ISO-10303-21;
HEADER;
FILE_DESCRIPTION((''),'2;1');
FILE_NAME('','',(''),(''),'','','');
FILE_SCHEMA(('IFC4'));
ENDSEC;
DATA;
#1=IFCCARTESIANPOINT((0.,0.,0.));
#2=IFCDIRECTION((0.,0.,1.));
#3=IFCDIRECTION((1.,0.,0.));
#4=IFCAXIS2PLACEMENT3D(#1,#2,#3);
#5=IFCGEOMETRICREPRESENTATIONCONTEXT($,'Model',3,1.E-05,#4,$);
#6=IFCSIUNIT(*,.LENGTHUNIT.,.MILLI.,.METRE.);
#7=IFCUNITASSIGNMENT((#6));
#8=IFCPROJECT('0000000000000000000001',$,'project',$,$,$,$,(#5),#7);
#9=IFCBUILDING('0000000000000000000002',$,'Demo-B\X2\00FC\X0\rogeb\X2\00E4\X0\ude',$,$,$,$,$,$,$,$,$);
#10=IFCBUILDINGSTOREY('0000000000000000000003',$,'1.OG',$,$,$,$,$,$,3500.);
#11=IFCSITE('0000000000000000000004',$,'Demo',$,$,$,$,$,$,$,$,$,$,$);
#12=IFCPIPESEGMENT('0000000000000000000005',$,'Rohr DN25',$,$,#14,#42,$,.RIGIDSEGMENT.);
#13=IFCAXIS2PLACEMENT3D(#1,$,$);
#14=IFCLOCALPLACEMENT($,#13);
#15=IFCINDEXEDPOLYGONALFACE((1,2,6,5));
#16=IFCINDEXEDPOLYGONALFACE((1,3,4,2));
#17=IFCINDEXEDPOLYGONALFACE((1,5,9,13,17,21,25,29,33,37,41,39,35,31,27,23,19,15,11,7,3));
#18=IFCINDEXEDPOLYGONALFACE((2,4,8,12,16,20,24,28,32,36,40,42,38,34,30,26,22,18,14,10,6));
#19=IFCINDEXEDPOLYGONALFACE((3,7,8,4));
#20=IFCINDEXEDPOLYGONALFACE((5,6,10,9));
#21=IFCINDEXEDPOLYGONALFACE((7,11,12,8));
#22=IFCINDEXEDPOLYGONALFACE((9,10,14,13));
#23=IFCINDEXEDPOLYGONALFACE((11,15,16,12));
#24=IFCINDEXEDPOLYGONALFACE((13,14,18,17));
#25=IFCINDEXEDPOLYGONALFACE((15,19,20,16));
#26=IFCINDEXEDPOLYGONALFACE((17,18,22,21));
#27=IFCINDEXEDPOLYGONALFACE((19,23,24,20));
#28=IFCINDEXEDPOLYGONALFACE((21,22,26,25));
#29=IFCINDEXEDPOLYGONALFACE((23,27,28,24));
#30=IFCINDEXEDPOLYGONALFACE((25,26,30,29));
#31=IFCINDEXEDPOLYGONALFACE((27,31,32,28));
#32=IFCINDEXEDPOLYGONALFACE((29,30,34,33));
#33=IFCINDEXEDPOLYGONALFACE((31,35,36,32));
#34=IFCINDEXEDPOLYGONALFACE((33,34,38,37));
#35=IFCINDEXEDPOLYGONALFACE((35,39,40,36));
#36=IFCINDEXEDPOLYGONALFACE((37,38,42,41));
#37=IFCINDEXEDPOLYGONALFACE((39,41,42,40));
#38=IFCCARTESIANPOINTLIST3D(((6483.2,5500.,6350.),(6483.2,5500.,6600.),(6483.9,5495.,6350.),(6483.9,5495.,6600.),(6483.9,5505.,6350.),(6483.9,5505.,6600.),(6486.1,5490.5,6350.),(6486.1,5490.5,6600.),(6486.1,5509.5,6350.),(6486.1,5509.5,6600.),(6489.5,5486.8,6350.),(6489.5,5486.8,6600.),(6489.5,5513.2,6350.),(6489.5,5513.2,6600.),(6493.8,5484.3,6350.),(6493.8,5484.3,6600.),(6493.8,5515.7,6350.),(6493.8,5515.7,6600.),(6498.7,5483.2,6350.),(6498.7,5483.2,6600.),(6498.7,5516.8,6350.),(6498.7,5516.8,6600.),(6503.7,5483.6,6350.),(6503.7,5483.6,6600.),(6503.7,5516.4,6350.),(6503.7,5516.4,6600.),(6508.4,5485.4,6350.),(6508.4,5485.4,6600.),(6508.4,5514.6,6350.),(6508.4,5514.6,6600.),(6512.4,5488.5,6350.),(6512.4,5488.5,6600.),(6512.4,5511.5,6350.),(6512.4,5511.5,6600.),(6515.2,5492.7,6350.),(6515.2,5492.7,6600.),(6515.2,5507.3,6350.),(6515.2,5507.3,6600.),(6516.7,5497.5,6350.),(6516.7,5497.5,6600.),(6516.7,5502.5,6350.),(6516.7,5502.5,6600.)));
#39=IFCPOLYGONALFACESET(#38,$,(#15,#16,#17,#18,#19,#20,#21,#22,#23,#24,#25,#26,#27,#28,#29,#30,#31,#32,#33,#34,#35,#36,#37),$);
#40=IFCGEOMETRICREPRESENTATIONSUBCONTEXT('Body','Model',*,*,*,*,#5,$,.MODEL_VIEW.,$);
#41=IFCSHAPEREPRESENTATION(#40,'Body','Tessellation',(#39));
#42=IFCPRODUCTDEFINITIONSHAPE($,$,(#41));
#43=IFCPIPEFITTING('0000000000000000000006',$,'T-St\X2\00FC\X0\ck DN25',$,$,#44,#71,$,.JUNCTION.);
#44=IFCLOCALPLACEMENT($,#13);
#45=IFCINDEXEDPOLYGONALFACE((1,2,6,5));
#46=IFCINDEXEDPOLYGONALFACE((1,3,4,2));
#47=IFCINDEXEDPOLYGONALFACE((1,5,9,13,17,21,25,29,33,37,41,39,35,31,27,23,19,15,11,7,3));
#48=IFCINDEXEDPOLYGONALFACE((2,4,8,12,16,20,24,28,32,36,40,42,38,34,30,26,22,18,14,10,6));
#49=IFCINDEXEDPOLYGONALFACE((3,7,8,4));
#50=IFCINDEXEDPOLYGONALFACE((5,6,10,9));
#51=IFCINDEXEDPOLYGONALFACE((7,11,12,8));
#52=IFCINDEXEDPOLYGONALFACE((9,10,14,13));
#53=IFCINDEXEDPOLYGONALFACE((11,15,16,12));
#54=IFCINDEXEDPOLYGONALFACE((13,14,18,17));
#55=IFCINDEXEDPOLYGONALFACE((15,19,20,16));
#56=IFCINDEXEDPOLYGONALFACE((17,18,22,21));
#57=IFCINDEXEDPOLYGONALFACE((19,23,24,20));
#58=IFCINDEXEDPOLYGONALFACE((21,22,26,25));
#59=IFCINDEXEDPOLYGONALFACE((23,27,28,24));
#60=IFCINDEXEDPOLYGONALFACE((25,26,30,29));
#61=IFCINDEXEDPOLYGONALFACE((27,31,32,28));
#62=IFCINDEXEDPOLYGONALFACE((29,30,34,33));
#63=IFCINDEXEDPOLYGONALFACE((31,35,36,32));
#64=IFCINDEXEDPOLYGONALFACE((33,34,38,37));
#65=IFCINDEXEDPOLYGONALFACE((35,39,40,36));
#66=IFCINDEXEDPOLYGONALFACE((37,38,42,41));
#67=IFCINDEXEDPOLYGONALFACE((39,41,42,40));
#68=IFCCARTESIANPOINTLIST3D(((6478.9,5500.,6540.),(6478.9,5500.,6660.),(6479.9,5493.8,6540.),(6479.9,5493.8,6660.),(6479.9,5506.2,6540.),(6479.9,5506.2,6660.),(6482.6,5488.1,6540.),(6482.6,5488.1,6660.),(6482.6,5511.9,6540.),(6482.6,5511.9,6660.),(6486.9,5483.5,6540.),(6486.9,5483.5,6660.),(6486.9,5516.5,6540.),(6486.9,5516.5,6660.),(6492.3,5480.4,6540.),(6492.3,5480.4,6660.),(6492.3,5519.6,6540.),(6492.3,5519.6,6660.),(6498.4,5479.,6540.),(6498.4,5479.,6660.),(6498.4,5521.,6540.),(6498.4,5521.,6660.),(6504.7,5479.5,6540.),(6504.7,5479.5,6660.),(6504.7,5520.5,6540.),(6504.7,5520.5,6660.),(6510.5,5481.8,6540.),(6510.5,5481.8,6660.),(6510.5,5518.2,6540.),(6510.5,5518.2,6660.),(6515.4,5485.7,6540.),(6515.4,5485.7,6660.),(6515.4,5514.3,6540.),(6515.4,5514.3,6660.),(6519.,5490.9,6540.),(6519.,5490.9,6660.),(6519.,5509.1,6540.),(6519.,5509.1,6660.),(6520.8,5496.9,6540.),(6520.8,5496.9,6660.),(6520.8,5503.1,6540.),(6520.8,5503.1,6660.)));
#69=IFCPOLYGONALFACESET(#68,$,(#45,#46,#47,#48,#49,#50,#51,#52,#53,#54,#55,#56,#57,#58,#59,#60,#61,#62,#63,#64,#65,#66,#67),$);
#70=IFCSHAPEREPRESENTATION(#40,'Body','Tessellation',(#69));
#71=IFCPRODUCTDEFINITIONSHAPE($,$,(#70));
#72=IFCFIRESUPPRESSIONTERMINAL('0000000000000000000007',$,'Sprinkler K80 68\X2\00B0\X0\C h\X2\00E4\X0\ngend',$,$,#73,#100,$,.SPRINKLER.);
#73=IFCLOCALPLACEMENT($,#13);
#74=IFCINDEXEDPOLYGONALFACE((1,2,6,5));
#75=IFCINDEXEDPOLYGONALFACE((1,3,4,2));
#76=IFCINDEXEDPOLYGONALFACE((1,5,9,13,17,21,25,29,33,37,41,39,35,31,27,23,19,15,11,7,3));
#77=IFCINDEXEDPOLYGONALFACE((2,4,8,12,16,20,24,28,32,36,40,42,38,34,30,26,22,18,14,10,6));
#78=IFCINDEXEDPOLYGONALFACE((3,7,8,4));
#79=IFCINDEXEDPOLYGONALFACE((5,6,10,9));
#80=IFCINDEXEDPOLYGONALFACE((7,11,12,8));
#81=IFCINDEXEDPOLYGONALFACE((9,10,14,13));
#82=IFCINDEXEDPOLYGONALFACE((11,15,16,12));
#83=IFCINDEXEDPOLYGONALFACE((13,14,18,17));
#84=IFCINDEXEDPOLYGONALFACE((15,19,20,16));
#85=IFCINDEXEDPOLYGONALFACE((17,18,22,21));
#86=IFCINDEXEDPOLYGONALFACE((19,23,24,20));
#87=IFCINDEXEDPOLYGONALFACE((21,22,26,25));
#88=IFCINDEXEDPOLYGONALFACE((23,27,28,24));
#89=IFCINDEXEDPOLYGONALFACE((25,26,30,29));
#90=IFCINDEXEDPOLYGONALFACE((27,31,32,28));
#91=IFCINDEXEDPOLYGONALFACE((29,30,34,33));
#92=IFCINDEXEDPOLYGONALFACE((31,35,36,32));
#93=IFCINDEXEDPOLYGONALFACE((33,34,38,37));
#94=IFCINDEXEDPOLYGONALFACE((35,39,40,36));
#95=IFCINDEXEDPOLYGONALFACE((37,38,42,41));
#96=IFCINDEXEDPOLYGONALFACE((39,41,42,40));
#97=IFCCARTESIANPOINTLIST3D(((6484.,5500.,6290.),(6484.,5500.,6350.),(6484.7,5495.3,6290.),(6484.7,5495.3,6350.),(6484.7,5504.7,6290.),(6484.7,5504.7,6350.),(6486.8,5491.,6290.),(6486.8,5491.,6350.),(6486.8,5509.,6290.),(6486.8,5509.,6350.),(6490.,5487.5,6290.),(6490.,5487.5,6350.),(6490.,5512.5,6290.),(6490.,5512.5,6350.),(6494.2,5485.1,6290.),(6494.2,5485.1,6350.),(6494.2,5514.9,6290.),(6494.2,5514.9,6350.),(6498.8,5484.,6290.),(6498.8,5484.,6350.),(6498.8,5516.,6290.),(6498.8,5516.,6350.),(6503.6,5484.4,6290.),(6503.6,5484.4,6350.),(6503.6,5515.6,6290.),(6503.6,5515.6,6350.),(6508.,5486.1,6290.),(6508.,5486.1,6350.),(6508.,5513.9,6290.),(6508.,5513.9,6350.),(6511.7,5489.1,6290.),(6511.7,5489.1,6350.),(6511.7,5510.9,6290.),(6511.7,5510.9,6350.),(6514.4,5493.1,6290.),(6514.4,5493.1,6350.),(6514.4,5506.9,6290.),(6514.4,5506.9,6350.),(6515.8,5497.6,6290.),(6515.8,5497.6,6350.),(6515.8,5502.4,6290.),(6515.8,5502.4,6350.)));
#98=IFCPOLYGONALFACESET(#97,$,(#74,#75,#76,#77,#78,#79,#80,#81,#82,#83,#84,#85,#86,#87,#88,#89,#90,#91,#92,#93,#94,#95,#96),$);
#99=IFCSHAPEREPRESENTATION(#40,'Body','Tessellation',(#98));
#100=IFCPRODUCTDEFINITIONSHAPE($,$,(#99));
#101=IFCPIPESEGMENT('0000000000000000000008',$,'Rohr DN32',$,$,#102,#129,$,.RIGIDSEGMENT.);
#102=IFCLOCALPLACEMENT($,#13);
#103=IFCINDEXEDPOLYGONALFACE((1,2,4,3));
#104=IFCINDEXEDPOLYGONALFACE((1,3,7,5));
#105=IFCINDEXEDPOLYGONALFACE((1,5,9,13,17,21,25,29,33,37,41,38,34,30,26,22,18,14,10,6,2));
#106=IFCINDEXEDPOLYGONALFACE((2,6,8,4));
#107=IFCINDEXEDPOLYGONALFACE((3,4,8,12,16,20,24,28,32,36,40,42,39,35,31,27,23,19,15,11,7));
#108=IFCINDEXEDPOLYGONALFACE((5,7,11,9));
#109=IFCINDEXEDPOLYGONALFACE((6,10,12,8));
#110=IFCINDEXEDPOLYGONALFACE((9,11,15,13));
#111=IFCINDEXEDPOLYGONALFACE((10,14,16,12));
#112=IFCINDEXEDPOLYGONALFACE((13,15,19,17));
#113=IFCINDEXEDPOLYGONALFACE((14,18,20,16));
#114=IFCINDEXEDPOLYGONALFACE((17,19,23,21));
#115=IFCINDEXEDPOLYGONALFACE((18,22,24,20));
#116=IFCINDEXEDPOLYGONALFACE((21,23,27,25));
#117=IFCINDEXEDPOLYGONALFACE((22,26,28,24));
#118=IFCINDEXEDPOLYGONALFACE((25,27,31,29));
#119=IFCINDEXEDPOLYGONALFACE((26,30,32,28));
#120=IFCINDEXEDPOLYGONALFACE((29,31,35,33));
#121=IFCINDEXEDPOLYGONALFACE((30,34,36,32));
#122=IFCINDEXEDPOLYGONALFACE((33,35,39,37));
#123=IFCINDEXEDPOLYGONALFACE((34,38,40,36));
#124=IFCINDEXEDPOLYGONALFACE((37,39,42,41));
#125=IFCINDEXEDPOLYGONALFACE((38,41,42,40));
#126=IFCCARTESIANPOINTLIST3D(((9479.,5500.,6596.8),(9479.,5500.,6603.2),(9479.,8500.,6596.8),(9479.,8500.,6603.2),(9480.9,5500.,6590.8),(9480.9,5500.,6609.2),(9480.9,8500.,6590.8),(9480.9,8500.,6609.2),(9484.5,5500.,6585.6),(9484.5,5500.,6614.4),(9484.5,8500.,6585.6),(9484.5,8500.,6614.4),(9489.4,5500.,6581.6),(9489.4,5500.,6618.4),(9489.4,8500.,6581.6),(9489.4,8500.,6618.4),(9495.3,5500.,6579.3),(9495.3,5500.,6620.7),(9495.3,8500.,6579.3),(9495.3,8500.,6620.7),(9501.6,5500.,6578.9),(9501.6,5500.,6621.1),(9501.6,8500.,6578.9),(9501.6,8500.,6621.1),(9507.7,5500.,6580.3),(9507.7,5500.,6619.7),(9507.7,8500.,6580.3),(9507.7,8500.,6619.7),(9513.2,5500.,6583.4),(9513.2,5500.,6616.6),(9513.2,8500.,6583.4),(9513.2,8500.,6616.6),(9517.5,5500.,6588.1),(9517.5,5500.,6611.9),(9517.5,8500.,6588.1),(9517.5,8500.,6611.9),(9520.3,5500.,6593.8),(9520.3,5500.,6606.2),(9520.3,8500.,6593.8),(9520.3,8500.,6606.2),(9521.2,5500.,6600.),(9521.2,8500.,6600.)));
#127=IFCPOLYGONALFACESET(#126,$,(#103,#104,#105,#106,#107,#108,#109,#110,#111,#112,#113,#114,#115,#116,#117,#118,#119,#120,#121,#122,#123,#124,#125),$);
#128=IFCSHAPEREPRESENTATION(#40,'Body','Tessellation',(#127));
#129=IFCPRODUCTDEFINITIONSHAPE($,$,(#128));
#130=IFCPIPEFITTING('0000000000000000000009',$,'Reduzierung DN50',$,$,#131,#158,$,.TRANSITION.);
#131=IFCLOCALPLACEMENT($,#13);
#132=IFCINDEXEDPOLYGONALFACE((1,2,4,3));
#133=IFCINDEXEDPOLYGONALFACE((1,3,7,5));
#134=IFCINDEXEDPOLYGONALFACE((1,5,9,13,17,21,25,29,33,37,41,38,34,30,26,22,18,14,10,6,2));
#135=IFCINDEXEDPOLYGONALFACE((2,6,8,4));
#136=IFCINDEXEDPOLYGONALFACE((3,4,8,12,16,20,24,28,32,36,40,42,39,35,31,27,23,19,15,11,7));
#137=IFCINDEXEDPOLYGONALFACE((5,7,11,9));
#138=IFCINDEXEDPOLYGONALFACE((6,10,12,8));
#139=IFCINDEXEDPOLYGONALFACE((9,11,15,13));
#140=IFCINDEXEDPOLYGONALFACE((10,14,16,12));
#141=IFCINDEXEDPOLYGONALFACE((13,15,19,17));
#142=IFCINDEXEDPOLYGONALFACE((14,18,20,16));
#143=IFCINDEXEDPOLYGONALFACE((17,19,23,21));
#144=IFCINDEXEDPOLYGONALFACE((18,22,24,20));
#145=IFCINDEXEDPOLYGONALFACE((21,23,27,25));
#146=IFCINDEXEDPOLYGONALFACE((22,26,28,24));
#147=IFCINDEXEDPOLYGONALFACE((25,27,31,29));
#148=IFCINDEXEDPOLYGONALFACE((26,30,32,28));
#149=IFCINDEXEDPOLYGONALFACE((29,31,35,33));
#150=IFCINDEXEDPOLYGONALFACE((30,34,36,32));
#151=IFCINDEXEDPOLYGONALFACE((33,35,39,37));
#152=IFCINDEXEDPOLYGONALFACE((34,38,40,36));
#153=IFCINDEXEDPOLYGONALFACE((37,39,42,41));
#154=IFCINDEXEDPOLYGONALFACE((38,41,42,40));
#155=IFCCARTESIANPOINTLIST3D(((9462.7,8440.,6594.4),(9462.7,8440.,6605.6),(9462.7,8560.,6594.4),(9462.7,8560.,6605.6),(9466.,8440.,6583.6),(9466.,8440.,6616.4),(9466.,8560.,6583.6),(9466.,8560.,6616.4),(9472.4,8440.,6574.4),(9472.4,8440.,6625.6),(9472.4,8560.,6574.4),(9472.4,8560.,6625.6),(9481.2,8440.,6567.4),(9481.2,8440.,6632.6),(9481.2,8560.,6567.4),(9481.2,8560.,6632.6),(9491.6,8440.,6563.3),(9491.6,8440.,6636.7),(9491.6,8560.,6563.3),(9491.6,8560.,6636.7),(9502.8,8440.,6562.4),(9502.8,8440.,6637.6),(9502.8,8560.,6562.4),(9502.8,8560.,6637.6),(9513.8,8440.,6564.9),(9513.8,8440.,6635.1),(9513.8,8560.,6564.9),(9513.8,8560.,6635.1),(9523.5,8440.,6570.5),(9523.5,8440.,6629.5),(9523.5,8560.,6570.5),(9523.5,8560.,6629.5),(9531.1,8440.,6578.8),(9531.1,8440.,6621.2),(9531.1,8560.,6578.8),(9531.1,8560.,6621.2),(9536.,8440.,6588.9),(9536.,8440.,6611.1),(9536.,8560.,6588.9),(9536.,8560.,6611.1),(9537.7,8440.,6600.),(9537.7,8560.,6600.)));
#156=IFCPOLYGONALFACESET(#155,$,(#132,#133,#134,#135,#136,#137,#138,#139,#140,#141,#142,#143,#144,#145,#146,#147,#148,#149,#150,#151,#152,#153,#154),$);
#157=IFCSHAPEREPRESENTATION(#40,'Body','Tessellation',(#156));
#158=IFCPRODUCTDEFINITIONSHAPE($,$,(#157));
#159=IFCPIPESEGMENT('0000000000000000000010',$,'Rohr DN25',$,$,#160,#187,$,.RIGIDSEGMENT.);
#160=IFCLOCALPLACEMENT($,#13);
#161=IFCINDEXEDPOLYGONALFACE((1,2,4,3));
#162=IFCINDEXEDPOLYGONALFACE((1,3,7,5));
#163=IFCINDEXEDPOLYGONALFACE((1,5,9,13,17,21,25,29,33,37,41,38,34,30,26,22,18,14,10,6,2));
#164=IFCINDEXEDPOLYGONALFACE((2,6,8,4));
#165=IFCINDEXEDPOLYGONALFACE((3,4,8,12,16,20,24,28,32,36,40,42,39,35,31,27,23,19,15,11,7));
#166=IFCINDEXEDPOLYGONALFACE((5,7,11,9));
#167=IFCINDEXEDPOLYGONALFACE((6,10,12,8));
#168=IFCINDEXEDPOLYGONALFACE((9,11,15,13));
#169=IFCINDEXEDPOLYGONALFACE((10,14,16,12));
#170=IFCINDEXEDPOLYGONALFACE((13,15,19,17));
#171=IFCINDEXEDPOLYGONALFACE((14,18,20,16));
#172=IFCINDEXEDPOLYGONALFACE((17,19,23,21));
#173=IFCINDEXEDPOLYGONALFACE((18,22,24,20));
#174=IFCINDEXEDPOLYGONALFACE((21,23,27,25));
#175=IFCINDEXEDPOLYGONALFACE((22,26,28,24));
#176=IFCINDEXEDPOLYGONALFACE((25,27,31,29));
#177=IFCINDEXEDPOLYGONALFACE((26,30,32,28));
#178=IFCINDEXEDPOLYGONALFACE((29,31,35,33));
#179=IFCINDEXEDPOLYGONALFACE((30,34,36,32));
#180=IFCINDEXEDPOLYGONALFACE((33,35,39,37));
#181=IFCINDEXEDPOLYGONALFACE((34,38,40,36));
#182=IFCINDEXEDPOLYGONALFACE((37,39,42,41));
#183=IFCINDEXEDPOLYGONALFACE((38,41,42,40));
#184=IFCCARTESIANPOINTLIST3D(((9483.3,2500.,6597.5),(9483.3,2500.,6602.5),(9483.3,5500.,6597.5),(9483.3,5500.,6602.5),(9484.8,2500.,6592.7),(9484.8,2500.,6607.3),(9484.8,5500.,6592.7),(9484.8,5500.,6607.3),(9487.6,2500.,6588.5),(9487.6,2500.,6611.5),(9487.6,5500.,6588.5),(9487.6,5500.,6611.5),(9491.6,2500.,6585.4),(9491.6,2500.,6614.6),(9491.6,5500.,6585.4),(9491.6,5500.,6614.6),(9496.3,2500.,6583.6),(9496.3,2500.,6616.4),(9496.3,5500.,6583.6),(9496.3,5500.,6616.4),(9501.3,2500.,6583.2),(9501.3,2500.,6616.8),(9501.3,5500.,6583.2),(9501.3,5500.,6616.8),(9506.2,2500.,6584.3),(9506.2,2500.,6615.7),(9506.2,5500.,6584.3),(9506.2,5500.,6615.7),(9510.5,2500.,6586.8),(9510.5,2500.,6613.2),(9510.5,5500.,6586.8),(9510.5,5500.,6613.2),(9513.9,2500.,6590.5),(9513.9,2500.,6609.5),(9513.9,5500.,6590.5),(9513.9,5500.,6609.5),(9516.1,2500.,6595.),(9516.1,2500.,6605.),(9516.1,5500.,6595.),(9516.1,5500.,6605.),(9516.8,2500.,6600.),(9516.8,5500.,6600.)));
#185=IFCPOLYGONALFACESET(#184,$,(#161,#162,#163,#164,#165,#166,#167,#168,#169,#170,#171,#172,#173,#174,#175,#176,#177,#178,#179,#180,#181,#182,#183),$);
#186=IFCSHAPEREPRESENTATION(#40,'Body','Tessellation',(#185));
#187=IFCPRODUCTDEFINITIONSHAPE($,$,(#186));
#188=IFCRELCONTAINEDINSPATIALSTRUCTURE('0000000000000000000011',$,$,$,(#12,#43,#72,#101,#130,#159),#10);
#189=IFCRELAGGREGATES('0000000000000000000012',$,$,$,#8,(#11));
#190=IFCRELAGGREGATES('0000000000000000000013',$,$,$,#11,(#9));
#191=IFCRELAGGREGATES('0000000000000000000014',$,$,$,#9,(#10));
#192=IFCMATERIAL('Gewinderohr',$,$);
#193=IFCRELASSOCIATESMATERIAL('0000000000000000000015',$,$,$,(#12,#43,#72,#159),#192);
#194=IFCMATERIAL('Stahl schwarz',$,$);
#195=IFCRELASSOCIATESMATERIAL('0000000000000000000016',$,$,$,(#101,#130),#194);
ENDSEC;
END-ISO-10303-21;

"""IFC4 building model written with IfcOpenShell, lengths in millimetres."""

from ifc_helpers import new_model, si_unit, frame, origin_with_axes, place, context, subcontext, project, spatial, circle, extrude, material, element, save


model = new_model("IFC4")

# Units and contexts
model_context = context("Model", 3, precision=1e-05, world=origin_with_axes())
body_context = subcontext(model_context, "Body", "Model", "MODEL_VIEW")
ifc_project = project(units=[si_unit("LENGTHUNIT", "METRE", prefix="MILLI")], contexts=[model_context])

# Site, building, storey
site = spatial("IfcSite", under=ifc_project, Name="Demo")
building = spatial("IfcBuilding", under=site, Name="Demo-Bürogebäude")
storey = spatial("IfcBuildingStorey", under=building, Name="1.OG", Elevation=3500.0)

# Shared definitions
ifc_material_1 = material(Name="Stahl schwarz")

# Shared definitions
ifc_material_2 = material(Name="Gewinderohr")

# Pipe segment
pipe_segment_1_placement = place(None, frame((6500.0, 5500.0, 6600.0), z_axis=(0.0, 0.0, -1.0), x_axis=(-1.0, 0.0, 0.0)))
element("IfcPipeSegment", 1, at=pipe_segment_1_placement, inside=storey, material=ifc_material_2, Name="Rohr DN25", PredefinedType="RIGIDSEGMENT", context=body_context, shape_type="SweptSolid", body=[
    extrude(circle(Radius=16.9), origin_with_axes(), (0.0, 0.0, 1.0), 250.0),
])

# Pipe fitting
pipe_fitting_1_placement = place(None, frame((6500.0, 5500.0, 6660.0), z_axis=(0.0, 0.0, -1.0), x_axis=(-1.0, 0.0, 0.0)))
element("IfcPipeFitting", 2, at=pipe_fitting_1_placement, inside=storey, material=ifc_material_2, Name="T-Stück DN25", PredefinedType="JUNCTION", context=body_context, shape_type="SweptSolid", body=[
    extrude(circle(Radius=21.1), origin_with_axes(), (0.0, 0.0, 1.0), 120.0),
])

# Fire suppression terminal
fire_suppression_terminal_1_placement = place(None, frame((6500.0, 5500.0, 6350.0), z_axis=(0.0, 0.0, -1.0), x_axis=(-1.0, 0.0, 0.0)))
element("IfcFireSuppressionTerminal", 3, at=fire_suppression_terminal_1_placement, inside=storey, material=ifc_material_2, Name="Sprinkler K80 68°C hängend", PredefinedType="SPRINKLER", context=body_context, shape_type="SweptSolid", body=[
    extrude(circle(Radius=16.0), origin_with_axes(), (0.0, 0.0, 1.0), 60.0),
])

# Pipe segment
pipe_segment_2_placement = place(None, frame((9500.0, 8500.0, 6600.0), z_axis=(0.0, -1.0, 0.0), x_axis=(1.0, 0.0, 0.0)))
element("IfcPipeSegment", 4, at=pipe_segment_2_placement, inside=storey, material=ifc_material_1, Name="Rohr DN32", PredefinedType="RIGIDSEGMENT", context=body_context, shape_type="SweptSolid", body=[
    extrude(circle(Radius=21.2), origin_with_axes(), (0.0, 0.0, 1.0), 3000.0),
])

# Pipe fitting
pipe_fitting_2_placement = place(None, frame((9500.0, 8560.0, 6600.0), z_axis=(0.0, -1.0, 0.0), x_axis=(1.0, 0.0, 0.0)))
element("IfcPipeFitting", 5, at=pipe_fitting_2_placement, inside=storey, material=ifc_material_1, Name="Reduzierung DN50", PredefinedType="TRANSITION", context=body_context, shape_type="SweptSolid", body=[
    extrude(circle(Radius=37.7), origin_with_axes(), (0.0, 0.0, 1.0), 120.0),
])

# Pipe segment
pipe_segment_3_placement = place(None, frame((9500.0, 5500.0, 6600.0), z_axis=(0.0, -1.0, 0.0), x_axis=(1.0, 0.0, 0.0)))
element("IfcPipeSegment", 6, at=pipe_segment_3_placement, inside=storey, material=ifc_material_2, Name="Rohr DN25", PredefinedType="RIGIDSEGMENT", context=body_context, shape_type="SweptSolid", body=[
    extrude(circle(Radius=16.9), origin_with_axes(), (0.0, 0.0, 1.0), 3000.0),
])

save(model, "model.ifc")
